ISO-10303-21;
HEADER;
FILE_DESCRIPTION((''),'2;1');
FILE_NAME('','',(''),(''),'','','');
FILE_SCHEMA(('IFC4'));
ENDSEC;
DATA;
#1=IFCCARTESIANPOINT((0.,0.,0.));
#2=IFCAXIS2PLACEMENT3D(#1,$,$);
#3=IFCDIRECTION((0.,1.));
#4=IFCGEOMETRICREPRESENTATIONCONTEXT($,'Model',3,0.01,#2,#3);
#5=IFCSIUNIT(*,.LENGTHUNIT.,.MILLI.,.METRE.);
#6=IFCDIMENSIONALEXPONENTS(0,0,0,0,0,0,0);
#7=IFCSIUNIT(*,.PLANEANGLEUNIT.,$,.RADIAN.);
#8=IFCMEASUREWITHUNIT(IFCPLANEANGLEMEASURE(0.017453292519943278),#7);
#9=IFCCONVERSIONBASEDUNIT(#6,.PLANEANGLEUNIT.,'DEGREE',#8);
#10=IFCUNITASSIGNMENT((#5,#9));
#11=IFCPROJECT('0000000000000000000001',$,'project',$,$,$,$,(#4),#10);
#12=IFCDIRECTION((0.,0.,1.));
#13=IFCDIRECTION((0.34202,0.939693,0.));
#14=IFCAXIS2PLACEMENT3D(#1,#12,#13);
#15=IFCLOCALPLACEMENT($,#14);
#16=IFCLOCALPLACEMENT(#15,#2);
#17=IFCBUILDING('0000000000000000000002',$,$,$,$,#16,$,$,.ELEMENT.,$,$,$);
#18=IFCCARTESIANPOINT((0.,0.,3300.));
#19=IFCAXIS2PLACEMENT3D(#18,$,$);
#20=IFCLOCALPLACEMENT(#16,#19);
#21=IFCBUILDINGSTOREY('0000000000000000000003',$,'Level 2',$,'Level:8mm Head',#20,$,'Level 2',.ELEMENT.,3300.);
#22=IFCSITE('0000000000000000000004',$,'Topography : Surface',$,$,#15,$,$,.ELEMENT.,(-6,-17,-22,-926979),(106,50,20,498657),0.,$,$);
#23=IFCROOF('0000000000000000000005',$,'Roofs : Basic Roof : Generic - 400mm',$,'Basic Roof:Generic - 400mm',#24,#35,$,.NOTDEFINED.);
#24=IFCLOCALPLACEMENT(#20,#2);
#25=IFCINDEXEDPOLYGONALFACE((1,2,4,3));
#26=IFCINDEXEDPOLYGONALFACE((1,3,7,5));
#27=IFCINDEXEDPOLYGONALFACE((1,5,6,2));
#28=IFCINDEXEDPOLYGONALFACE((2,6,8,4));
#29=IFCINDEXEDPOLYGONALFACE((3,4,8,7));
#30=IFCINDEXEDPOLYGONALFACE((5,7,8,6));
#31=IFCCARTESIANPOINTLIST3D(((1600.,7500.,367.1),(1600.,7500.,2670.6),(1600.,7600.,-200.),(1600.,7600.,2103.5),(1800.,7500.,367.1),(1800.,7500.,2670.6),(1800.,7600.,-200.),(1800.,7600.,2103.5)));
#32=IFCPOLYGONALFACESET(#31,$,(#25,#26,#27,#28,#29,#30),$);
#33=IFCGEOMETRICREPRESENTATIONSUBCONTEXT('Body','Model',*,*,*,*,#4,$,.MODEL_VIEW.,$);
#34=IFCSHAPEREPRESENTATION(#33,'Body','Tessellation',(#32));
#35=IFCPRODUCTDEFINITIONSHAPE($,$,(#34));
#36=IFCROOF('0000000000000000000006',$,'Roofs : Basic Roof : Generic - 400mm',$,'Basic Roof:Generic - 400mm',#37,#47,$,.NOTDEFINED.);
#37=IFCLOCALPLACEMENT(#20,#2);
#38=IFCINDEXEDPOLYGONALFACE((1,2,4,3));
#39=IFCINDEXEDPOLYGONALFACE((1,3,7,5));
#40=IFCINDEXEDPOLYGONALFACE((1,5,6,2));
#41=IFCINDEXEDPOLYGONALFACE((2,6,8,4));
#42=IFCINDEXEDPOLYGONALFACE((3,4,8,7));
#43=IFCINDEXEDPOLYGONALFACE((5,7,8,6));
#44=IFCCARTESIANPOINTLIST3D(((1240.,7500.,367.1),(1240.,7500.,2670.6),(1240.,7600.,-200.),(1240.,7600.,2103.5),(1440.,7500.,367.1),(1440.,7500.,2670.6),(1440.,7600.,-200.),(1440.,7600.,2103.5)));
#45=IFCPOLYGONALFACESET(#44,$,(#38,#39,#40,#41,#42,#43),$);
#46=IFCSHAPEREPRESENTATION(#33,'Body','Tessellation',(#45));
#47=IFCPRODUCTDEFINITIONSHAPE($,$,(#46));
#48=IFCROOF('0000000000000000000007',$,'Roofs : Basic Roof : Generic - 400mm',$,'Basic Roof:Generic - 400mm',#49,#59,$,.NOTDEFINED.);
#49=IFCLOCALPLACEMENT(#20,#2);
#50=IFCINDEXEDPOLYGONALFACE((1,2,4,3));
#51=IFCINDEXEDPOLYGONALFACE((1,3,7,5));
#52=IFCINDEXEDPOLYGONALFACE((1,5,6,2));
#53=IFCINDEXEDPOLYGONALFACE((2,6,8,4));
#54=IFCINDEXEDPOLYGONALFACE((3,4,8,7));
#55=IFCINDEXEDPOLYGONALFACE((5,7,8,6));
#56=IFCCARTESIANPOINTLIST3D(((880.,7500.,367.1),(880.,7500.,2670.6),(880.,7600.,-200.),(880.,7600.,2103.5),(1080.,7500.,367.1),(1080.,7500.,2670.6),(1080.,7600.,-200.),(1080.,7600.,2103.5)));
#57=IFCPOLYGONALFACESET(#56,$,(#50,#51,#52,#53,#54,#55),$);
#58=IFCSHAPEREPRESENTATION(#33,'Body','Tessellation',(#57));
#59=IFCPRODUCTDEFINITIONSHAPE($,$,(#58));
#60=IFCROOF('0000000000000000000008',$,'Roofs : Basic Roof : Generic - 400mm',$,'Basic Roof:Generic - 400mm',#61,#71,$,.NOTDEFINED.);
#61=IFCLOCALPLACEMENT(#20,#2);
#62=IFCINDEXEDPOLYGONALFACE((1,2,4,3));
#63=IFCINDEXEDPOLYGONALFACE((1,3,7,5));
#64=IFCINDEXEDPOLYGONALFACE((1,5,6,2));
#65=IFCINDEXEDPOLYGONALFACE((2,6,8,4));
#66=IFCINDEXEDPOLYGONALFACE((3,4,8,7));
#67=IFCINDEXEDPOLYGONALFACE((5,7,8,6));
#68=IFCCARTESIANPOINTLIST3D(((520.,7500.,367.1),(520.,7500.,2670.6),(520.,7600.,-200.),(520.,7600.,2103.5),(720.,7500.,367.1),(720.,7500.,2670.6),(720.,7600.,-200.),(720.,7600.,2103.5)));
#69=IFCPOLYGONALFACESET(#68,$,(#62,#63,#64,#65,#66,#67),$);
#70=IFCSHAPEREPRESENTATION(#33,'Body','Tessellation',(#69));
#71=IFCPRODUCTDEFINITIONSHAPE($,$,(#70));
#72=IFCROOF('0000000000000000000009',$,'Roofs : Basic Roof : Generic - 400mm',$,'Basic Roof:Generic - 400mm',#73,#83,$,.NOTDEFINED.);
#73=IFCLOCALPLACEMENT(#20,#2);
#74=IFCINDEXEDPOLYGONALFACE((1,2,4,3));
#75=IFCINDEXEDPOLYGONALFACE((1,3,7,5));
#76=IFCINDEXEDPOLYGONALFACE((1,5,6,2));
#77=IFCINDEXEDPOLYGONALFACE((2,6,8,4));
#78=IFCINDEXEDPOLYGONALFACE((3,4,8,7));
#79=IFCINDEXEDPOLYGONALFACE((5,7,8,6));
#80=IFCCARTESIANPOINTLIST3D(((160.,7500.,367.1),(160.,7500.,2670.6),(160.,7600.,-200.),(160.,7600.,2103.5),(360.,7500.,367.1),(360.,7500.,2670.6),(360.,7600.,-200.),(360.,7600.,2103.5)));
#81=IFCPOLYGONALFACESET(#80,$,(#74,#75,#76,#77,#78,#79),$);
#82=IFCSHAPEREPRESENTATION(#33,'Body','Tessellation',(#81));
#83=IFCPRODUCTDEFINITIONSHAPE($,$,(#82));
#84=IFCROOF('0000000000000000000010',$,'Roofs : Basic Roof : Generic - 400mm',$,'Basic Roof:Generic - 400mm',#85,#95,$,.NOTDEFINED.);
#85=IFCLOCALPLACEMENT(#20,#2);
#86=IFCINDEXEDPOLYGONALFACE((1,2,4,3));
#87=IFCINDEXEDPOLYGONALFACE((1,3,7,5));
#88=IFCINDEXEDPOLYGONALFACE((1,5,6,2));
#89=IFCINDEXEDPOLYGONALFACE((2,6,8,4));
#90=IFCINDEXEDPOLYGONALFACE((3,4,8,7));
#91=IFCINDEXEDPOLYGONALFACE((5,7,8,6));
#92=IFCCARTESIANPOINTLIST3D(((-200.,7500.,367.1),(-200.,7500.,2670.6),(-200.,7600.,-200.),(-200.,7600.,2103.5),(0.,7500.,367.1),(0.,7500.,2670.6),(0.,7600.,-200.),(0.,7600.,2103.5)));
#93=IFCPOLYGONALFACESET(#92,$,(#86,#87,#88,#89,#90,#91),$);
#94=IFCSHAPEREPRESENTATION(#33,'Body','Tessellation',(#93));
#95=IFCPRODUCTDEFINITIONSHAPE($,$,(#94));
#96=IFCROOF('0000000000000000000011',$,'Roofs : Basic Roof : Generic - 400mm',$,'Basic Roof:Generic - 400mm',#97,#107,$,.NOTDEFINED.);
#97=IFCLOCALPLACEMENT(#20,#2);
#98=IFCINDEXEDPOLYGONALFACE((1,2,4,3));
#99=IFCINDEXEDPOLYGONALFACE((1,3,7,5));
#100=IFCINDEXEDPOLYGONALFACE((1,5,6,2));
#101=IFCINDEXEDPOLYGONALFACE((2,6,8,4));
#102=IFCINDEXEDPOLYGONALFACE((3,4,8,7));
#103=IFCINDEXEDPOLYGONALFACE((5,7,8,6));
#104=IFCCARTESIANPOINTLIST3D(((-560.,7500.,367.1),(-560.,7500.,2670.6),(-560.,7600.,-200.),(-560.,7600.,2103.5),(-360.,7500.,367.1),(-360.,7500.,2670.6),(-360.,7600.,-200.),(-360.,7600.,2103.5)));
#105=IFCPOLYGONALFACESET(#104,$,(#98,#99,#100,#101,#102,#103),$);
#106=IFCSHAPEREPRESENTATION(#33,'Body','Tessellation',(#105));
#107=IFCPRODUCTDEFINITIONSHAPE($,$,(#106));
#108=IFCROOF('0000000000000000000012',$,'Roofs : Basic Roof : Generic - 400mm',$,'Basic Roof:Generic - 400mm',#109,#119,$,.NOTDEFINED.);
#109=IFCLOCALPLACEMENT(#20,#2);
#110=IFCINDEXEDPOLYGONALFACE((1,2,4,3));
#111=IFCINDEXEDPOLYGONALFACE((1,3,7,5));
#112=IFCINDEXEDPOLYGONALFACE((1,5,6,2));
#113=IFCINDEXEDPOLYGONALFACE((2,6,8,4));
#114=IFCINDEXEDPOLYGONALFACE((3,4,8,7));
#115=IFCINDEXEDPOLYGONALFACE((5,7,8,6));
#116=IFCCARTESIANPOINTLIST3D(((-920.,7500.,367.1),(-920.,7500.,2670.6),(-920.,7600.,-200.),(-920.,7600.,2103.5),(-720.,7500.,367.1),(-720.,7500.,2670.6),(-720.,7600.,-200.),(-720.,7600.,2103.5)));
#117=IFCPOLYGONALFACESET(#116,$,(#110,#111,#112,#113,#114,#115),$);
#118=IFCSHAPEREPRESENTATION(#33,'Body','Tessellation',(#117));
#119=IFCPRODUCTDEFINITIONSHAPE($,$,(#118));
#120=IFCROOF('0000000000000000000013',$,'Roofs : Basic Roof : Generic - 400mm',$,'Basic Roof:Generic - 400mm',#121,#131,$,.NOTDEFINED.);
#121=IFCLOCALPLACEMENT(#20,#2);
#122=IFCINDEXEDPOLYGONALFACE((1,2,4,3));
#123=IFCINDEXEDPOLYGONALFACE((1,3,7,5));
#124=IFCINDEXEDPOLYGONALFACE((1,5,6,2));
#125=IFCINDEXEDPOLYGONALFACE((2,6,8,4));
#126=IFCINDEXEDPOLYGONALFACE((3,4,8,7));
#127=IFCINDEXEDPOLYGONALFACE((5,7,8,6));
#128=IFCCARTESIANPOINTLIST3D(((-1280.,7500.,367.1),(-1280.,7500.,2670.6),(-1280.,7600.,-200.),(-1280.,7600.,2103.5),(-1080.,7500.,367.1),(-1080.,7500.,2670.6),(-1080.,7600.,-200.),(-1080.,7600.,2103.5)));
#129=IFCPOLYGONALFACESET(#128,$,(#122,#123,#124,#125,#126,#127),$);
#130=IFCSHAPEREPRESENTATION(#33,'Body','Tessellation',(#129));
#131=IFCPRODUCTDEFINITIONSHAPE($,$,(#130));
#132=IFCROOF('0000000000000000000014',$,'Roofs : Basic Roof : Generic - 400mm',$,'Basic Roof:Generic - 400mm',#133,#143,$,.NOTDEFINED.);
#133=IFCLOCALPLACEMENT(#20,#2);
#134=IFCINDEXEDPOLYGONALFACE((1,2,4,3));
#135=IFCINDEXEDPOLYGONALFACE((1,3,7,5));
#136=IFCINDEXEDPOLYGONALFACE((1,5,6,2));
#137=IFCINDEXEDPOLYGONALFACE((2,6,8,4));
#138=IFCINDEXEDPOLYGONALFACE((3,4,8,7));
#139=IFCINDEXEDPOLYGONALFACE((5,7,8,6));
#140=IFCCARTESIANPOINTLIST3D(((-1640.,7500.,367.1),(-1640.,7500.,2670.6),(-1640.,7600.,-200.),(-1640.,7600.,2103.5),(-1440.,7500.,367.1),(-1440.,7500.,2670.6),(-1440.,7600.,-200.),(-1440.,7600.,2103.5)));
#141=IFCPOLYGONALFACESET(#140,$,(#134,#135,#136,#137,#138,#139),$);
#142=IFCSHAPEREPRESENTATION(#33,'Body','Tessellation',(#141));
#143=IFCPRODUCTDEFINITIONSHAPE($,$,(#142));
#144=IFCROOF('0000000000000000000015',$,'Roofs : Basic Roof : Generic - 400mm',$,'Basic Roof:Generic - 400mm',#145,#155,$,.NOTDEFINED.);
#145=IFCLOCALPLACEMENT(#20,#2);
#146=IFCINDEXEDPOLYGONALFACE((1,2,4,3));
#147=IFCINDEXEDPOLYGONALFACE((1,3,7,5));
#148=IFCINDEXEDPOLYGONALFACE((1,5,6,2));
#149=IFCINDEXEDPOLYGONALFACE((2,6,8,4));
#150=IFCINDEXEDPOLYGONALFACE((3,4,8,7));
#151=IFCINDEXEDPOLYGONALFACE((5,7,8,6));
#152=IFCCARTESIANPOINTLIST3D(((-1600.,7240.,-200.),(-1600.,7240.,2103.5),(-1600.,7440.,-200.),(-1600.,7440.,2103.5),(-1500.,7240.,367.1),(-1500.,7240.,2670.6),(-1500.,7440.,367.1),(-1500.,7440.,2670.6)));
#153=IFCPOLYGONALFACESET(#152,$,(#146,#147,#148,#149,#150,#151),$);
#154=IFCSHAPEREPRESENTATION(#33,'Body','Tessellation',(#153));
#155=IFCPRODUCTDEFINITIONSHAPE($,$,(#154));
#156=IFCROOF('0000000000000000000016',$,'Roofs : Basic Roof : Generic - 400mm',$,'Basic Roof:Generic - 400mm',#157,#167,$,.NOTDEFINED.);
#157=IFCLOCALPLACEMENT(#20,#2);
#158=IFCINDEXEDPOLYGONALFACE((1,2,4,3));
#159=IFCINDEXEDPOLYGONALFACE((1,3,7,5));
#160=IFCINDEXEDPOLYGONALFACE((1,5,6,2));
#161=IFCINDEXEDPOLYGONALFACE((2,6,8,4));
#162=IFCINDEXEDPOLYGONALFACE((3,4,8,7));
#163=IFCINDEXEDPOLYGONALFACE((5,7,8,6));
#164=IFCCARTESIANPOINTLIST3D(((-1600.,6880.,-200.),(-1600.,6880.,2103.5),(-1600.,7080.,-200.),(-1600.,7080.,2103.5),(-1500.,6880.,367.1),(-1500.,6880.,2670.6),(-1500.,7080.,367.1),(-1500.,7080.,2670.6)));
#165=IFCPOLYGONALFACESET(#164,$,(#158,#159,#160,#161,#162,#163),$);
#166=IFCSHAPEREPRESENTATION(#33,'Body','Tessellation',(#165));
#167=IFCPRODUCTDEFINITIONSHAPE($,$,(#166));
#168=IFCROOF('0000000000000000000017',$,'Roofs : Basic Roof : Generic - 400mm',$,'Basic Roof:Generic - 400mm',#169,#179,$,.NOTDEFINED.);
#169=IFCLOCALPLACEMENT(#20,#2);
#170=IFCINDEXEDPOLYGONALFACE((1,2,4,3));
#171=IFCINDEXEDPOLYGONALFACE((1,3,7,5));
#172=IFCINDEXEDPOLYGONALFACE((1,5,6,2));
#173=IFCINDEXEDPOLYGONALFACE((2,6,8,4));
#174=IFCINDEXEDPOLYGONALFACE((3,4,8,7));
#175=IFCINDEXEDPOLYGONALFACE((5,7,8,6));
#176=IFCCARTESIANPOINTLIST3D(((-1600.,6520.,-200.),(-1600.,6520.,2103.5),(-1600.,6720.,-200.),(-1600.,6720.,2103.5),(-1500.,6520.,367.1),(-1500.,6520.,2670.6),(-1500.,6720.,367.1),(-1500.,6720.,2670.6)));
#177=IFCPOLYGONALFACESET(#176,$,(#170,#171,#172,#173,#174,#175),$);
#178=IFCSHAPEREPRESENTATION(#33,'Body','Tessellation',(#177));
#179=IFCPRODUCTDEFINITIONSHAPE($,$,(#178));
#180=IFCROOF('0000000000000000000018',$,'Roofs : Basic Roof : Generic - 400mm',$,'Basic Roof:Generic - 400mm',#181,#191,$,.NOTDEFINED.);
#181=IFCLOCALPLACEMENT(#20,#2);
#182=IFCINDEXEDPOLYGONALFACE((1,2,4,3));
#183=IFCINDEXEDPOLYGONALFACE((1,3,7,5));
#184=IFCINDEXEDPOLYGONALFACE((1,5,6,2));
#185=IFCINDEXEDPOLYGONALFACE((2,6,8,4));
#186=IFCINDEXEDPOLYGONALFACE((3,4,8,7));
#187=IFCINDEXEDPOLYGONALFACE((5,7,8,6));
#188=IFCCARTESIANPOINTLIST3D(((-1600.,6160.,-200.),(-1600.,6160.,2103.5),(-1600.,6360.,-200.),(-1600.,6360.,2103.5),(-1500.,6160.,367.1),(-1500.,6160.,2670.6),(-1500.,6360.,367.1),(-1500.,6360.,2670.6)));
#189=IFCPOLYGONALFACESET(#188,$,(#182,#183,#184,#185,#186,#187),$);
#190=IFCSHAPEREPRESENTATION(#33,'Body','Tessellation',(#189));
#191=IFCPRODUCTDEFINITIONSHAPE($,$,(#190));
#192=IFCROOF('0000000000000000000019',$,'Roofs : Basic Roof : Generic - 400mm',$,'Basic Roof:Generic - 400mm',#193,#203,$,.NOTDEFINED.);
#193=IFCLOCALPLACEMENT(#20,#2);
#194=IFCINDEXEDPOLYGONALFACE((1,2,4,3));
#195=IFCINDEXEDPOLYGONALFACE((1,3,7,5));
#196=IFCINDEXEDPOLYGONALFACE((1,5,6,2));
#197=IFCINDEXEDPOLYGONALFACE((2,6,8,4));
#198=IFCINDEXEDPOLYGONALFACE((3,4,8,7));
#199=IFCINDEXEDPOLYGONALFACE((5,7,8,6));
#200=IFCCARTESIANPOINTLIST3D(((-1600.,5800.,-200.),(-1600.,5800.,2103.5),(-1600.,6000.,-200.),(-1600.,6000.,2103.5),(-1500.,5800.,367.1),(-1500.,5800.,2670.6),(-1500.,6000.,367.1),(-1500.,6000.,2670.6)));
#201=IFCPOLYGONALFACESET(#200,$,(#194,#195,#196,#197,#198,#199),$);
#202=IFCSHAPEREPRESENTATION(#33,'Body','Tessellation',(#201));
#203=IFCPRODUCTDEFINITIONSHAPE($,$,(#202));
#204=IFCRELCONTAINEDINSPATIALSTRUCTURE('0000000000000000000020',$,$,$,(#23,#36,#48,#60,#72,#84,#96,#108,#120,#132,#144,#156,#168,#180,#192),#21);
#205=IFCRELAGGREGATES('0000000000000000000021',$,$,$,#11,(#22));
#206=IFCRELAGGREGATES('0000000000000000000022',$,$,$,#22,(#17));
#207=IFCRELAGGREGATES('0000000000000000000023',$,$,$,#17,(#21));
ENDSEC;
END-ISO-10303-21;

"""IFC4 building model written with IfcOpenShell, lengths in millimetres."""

from ifc_helpers import new_model, entity, si_unit, converted_unit, direction, frame, origin, place, context, subcontext, project, spatial, indexed_curve, outline, extrude, element, save


model = new_model("IFC4")

# Units and contexts
model_context = context("Model", 3, precision=0.01, world=origin(), true_north=direction((0.0, 1.0)))
body_context = subcontext(model_context, "Body", "Model", "MODEL_VIEW")
ifc_project = project(units=[si_unit("LENGTHUNIT", "METRE", prefix="MILLI"), converted_unit("PLANEANGLEUNIT", "DEGREE", entity("IfcPlaneAngleMeasure", 0.017453292519943278), si_unit("PLANEANGLEUNIT", "RADIAN"), dimensions=[0, 0, 0, 0, 0, 0, 0])], contexts=[model_context])

# Site, building, storey
site_placement = place(None, frame((0.0, 0.0, 0.0), z_axis=(0.0, 0.0, 1.0), x_axis=(0.34202, 0.939693, 0.0)))
site = spatial("IfcSite", under=ifc_project, at=site_placement, Name="Topography : Surface", CompositionType="ELEMENT", RefLatitude=(-6, -17, -22, -926979), RefLongitude=(106, 50, 20, 498657), RefElevation=0.0)
building_placement = place(site_placement, origin())
building = spatial("IfcBuilding", under=site, at=building_placement, CompositionType="ELEMENT")
storey_placement = place(building_placement, frame((0.0, 0.0, 3300.0)))
storey = spatial("IfcBuildingStorey", under=building, at=storey_placement, Name="Level 2", ObjectType="Level:8mm Head", LongName="Level 2", CompositionType="ELEMENT", Elevation=3300.0)

# Roofs
for number, where, name in (
    (1, (1600.0, 7500.0, -200.0), "Roofs : Basic Roof : Generic - 400mm"),
    (2, (1240.0, 7500.0, -200.0), "Roofs : Basic Roof : Generic - 400mm"),
):
    element("IfcRoof", number, at=place(storey_placement, frame(where)), inside=storey, Name=name, ObjectType="Basic Roof:Generic - 400mm", PredefinedType="NOTDEFINED", context=body_context, shape_type="SweptSolid", body=[
        extrude(outline(indexed_curve([(100.0, 287.9), (-100.0, 287.9), (-100.0, -287.9), (100.0, -287.9), (100.0, 287.9)], self_intersect=False)), frame((100.0, 50.0, 283.6), z_axis=(0.0, 0.984808, 0.173648), x_axis=(1.0, 0.0, 0.0)), (0.0, -0.984808, 0.173648), 2303.5),
    ])
for number, where, name in (
    (3, (880.0, 7500.0, -200.0), "Roofs : Basic Roof : Generic - 400mm"),
    (4, (520.0, 7500.0, -200.0), "Roofs : Basic Roof : Generic - 400mm"),
    (5, (160.0, 7500.0, -200.0), "Roofs : Basic Roof : Generic - 400mm"),
    (6, (-200.0, 7500.0, -200.0), "Roofs : Basic Roof : Generic - 400mm"),
    (7, (-560.0, 7500.0, -200.0), "Roofs : Basic Roof : Generic - 400mm"),
):
    element("IfcRoof", number, at=place(storey_placement, frame(where)), inside=storey, Name=name, ObjectType="Basic Roof:Generic - 400mm", PredefinedType="NOTDEFINED", context=body_context, shape_type="SweptSolid", body=[
        extrude(outline(indexed_curve([(100.0, 287.9), (-100.0, 287.9), (-100.0, -287.9), (100.0, -287.9), (100.0, 287.9)], self_intersect=False)), frame((100.0, 50.0, 283.6), z_axis=(0.0, 0.984808, 0.173648), x_axis=(1.0, 0.0, 0.0)), (0.0, -0.984808, 0.173648), 2303.5),
    ])
for number, where, name in (
    (8, (-920.0, 7500.0, -200.0), "Roofs : Basic Roof : Generic - 400mm"),
    (9, (-1280.0, 7500.0, -200.0), "Roofs : Basic Roof : Generic - 400mm"),
):
    element("IfcRoof", number, at=place(storey_placement, frame(where)), inside=storey, Name=name, ObjectType="Basic Roof:Generic - 400mm", PredefinedType="NOTDEFINED", context=body_context, shape_type="SweptSolid", body=[
        extrude(outline(indexed_curve([(100.0, 287.9), (-100.0, 287.9), (-100.0, -287.9), (100.0, -287.9), (100.0, 287.9)], self_intersect=False)), frame((100.0, 50.0, 283.6), z_axis=(0.0, 0.984808, 0.173648), x_axis=(1.0, 0.0, 0.0)), (0.0, -0.984808, 0.173648), 2303.5),
    ])
roof_1_placement = place(storey_placement, frame((-1640.0, 7500.0, -200.0)))
element("IfcRoof", 10, at=roof_1_placement, inside=storey, Name="Roofs : Basic Roof : Generic - 400mm", ObjectType="Basic Roof:Generic - 400mm", PredefinedType="NOTDEFINED", context=body_context, shape_type="SweptSolid", body=[
    extrude(outline(indexed_curve([(100.0, 287.9), (-100.0, 287.9), (-100.0, -287.9), (100.0, -287.9), (100.0, 287.9)], self_intersect=False)), frame((100.0, 50.0, 283.6), z_axis=(0.0, 0.984808, 0.173648), x_axis=(1.0, 0.0, 0.0)), (0.0, -0.984808, 0.173648), 2303.5),
])
roof_2_placement = place(storey_placement, frame((-1600.0, 7240.0, -200.0)))
element("IfcRoof", 11, at=roof_2_placement, inside=storey, Name="Roofs : Basic Roof : Generic - 400mm", ObjectType="Basic Roof:Generic - 400mm", PredefinedType="NOTDEFINED", context=body_context, shape_type="SweptSolid", body=[
    extrude(outline(indexed_curve([(-287.9, 100.0), (-287.9, -100.0), (287.9, -100.0), (287.9, 100.0), (-287.9, 100.0)], self_intersect=False)), frame((50.0, 100.0, 283.6), z_axis=(-0.984808, 0.0, 0.173648), x_axis=(0.173648, 0.0, 0.984808)), (0.984808, 0.0, 0.173648), 2303.5),
])
roof_3_placement = place(storey_placement, frame((-1600.0, 6880.0, -200.0)))
element("IfcRoof", 12, at=roof_3_placement, inside=storey, Name="Roofs : Basic Roof : Generic - 400mm", ObjectType="Basic Roof:Generic - 400mm", PredefinedType="NOTDEFINED", context=body_context, shape_type="SweptSolid", body=[
    extrude(outline(indexed_curve([(-287.9, 100.0), (-287.9, -100.0), (287.9, -100.0), (287.9, 100.0), (-287.9, 100.0)], self_intersect=False)), frame((50.0, 100.0, 283.6), z_axis=(-0.984808, 0.0, 0.173648), x_axis=(0.173648, 0.0, 0.984808)), (0.984808, 0.0, 0.173648), 2303.5),
])
roof_4_placement = place(storey_placement, frame((-1600.0, 6520.0, -200.0)))
element("IfcRoof", 13, at=roof_4_placement, inside=storey, Name="Roofs : Basic Roof : Generic - 400mm", ObjectType="Basic Roof:Generic - 400mm", PredefinedType="NOTDEFINED", context=body_context, shape_type="SweptSolid", body=[
    extrude(outline(indexed_curve([(-287.9, 100.0), (-287.9, -100.0), (287.9, -100.0), (287.9, 100.0), (-287.9, 100.0)], self_intersect=False)), frame((50.0, 100.0, 283.6), z_axis=(-0.984808, 0.0, 0.173648), x_axis=(0.173648, 0.0, 0.984808)), (0.984808, 0.0, 0.173648), 2303.5),
])
roof_5_placement = place(storey_placement, frame((-1600.0, 6160.0, -200.0)))
element("IfcRoof", 14, at=roof_5_placement, inside=storey, Name="Roofs : Basic Roof : Generic - 400mm", ObjectType="Basic Roof:Generic - 400mm", PredefinedType="NOTDEFINED", context=body_context, shape_type="SweptSolid", body=[
    extrude(outline(indexed_curve([(-287.9, 100.0), (-287.9, -100.0), (287.9, -100.0), (287.9, 100.0), (-287.9, 100.0)], self_intersect=False)), frame((50.0, 100.0, 283.6), z_axis=(-0.984808, 0.0, 0.173648), x_axis=(0.173648, 0.0, 0.984808)), (0.984808, 0.0, 0.173648), 2303.5),
])
roof_6_placement = place(storey_placement, frame((-1600.0, 5800.0, -200.0)))
element("IfcRoof", 15, at=roof_6_placement, inside=storey, Name="Roofs : Basic Roof : Generic - 400mm", ObjectType="Basic Roof:Generic - 400mm", PredefinedType="NOTDEFINED", context=body_context, shape_type="SweptSolid", body=[
    extrude(outline(indexed_curve([(-287.9, 100.0), (-287.9, -100.0), (287.9, -100.0), (287.9, 100.0), (-287.9, 100.0)], self_intersect=False)), frame((50.0, 100.0, 283.6), z_axis=(-0.984808, 0.0, 0.173648), x_axis=(0.173648, 0.0, 0.984808)), (0.984808, 0.0, 0.173648), 2303.5),
])

save(model, "model.ifc")
